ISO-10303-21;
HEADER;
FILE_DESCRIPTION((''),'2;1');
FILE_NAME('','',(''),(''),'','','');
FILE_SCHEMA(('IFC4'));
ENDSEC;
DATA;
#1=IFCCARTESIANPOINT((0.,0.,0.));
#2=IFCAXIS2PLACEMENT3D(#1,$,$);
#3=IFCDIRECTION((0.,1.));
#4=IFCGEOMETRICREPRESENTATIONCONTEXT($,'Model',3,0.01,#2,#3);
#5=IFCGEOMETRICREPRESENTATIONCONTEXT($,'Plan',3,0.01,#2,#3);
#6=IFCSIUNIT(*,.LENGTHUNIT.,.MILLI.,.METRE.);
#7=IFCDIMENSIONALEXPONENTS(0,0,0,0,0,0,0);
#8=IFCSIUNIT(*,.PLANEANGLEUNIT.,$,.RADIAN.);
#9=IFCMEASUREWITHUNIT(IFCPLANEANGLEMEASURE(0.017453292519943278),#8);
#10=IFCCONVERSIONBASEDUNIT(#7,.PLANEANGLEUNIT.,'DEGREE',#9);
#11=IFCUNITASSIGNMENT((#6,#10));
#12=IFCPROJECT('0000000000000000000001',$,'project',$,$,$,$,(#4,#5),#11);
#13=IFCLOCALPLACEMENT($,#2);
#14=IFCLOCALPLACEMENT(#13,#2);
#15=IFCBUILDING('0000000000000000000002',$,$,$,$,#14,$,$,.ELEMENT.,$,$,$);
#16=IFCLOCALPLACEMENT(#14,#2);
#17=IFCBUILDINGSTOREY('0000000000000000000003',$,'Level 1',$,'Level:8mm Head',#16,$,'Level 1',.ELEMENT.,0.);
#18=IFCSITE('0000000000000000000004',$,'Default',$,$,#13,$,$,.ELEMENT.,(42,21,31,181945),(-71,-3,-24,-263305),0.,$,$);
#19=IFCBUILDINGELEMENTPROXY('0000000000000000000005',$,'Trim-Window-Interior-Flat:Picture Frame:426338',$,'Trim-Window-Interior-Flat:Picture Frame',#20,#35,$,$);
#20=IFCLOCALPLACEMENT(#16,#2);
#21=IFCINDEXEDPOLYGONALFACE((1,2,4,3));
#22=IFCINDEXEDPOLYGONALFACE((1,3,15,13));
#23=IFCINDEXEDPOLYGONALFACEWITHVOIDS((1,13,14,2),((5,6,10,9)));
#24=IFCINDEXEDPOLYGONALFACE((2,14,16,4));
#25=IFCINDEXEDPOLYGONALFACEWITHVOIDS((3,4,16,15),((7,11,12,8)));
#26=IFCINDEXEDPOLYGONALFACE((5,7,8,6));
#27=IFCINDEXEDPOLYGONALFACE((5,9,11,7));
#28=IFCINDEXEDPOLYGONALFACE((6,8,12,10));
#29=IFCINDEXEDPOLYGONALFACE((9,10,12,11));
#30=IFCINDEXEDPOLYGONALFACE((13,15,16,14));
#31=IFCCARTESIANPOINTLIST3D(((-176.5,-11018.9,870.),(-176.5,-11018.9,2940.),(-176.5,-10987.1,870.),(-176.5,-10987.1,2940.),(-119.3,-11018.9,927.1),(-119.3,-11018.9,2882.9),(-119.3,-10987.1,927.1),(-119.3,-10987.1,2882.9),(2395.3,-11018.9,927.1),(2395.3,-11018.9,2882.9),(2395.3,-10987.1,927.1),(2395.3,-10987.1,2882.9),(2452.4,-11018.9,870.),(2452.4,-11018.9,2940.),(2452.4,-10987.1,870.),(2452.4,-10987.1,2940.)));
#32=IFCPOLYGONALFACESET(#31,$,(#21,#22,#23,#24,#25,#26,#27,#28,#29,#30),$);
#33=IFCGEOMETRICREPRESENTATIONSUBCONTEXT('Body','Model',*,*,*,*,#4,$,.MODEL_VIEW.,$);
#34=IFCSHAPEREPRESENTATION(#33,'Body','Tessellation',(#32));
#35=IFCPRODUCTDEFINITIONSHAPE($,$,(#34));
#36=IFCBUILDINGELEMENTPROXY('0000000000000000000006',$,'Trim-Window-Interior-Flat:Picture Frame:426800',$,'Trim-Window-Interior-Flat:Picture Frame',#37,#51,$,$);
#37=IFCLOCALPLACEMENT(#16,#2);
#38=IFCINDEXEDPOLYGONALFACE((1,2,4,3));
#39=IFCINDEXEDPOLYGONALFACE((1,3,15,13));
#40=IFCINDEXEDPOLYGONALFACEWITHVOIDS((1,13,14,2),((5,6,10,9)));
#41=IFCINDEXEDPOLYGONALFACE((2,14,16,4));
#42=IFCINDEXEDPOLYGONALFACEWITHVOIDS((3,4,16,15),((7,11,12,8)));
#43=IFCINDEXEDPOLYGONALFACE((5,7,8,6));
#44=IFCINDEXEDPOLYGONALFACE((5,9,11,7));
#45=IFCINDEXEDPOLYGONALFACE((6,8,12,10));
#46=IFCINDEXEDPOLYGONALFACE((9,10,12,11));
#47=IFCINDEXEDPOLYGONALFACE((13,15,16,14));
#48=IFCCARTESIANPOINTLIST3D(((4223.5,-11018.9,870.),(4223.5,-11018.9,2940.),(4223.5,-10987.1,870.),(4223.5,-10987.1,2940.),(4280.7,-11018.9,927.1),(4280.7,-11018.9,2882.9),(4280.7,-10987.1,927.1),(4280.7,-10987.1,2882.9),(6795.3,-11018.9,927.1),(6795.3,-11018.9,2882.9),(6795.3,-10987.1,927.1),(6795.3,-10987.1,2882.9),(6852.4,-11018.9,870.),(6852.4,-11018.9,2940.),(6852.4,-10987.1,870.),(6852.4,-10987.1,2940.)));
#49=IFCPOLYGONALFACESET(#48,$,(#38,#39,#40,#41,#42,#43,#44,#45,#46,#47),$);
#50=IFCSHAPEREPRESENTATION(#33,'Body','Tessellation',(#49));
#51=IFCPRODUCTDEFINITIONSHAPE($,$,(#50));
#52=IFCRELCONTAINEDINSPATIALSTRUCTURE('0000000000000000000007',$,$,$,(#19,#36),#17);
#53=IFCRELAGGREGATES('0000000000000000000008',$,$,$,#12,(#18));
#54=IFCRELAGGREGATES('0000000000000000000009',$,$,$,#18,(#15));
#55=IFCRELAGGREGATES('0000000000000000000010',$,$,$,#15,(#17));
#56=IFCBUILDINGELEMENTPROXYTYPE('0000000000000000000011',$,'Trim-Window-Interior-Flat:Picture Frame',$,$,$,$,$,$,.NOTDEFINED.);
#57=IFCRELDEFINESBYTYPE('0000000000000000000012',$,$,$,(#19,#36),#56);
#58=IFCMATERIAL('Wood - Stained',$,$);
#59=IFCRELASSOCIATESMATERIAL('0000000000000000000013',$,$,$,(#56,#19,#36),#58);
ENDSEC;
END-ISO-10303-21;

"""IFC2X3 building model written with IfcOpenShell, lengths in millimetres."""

from ifc_helpers import new_model, entity, si_unit, converted_unit, direction, frame, origin, place, context, subcontext, project, spatial, polyline, outline, extrude, source, transform, mapped, material, type_object, type_shapes, element, save


model = new_model("IFC2X3")

# Units and contexts
model_context = context("Model", 3, precision=0.01, world=origin(), true_north=direction((0.0, 1.0)))
plan_context = context("Plan", 3, precision=0.01, world=origin(), true_north=direction((0.0, 1.0)))
body_context = subcontext(model_context, "Body", "Model", "MODEL_VIEW")
ifc_project = project(units=[si_unit("LENGTHUNIT", "METRE", prefix="MILLI"), converted_unit("PLANEANGLEUNIT", "DEGREE", entity("IfcPlaneAngleMeasure", 0.017453292519943278), si_unit("PLANEANGLEUNIT", "RADIAN"), dimensions=[0, 0, 0, 0, 0, 0, 0])], contexts=[model_context, plan_context])

# Site, building, storey
site_placement = place(None, origin())
site = spatial("IfcSite", under=ifc_project, at=site_placement, Name="Default", CompositionType="ELEMENT", RefLatitude=(42, 21, 31, 181945), RefLongitude=(-71, -3, -24, -263305), RefElevation=0.0)
building_placement = place(site_placement, origin())
building = spatial("IfcBuilding", under=site, at=building_placement, CompositionType="ELEMENT")
storey_placement = place(building_placement, origin())
storey = spatial("IfcBuildingStorey", under=building, at=storey_placement, Name="Level 1", ObjectType="Level:8mm Head", LongName="Level 1", CompositionType="ELEMENT", Elevation=0.0)

# Building element proxies
ifc_material_1 = material(Name="Wood - Stained")
building_element_proxy_type_1 = type_object("IfcBuildingElementProxyType", Name="Trim-Window-Interior-Flat:Picture Frame", PredefinedType="NOTDEFINED", material=ifc_material_1)
shared_shape_1 = source(origin(), body_context, "Body", "SweptSolid", [
    extrude(outline(polyline([(-1314.4, -1035.0), (1314.4, -1035.0), (1314.4, 1035.0), (-1314.4, 1035.0), (-1314.4, -1035.0)]), holes=[polyline([(-1257.3, -977.9), (-1257.3, 977.9), (1257.3, 977.9), (1257.3, -977.9), (-1257.3, -977.9)])]), frame((0.0, -990.6, 0.0), z_axis=(0.0, 0.0, 1.0), x_axis=(-1.0, 0.0, 0.0)), (0.0, 0.0, 1.0), 31.7),
])
type_shapes(building_element_proxy_type_1, [shared_shape_1])
for number, where, z_axis, x_axis, name in (
    (1, (1138.0, -11018.9, 2895.6), (0.0, 1.0, 0.0), (-1.0, 0.0, 0.0), "Trim-Window-Interior-Flat:Picture Frame:426338"),
    (2, (5538.0, -11018.9, 2895.6), (0.0, 1.0, 0.0), (-1.0, 0.0, 0.0), "Trim-Window-Interior-Flat:Picture Frame:426800"),
):
    element("IfcBuildingElementProxy", number, at=place(storey_placement, frame(where, z_axis=z_axis, x_axis=x_axis)), inside=storey, type_object=building_element_proxy_type_1, material=ifc_material_1, Name=name, ObjectType="Trim-Window-Interior-Flat:Picture Frame", context=body_context, shape_type="MappedRepresentation", body=[
        mapped(shared_shape_1, transform((0.0, 0.0, 0.0), scale=1.0)),
    ])

save(model, "model.ifc")
